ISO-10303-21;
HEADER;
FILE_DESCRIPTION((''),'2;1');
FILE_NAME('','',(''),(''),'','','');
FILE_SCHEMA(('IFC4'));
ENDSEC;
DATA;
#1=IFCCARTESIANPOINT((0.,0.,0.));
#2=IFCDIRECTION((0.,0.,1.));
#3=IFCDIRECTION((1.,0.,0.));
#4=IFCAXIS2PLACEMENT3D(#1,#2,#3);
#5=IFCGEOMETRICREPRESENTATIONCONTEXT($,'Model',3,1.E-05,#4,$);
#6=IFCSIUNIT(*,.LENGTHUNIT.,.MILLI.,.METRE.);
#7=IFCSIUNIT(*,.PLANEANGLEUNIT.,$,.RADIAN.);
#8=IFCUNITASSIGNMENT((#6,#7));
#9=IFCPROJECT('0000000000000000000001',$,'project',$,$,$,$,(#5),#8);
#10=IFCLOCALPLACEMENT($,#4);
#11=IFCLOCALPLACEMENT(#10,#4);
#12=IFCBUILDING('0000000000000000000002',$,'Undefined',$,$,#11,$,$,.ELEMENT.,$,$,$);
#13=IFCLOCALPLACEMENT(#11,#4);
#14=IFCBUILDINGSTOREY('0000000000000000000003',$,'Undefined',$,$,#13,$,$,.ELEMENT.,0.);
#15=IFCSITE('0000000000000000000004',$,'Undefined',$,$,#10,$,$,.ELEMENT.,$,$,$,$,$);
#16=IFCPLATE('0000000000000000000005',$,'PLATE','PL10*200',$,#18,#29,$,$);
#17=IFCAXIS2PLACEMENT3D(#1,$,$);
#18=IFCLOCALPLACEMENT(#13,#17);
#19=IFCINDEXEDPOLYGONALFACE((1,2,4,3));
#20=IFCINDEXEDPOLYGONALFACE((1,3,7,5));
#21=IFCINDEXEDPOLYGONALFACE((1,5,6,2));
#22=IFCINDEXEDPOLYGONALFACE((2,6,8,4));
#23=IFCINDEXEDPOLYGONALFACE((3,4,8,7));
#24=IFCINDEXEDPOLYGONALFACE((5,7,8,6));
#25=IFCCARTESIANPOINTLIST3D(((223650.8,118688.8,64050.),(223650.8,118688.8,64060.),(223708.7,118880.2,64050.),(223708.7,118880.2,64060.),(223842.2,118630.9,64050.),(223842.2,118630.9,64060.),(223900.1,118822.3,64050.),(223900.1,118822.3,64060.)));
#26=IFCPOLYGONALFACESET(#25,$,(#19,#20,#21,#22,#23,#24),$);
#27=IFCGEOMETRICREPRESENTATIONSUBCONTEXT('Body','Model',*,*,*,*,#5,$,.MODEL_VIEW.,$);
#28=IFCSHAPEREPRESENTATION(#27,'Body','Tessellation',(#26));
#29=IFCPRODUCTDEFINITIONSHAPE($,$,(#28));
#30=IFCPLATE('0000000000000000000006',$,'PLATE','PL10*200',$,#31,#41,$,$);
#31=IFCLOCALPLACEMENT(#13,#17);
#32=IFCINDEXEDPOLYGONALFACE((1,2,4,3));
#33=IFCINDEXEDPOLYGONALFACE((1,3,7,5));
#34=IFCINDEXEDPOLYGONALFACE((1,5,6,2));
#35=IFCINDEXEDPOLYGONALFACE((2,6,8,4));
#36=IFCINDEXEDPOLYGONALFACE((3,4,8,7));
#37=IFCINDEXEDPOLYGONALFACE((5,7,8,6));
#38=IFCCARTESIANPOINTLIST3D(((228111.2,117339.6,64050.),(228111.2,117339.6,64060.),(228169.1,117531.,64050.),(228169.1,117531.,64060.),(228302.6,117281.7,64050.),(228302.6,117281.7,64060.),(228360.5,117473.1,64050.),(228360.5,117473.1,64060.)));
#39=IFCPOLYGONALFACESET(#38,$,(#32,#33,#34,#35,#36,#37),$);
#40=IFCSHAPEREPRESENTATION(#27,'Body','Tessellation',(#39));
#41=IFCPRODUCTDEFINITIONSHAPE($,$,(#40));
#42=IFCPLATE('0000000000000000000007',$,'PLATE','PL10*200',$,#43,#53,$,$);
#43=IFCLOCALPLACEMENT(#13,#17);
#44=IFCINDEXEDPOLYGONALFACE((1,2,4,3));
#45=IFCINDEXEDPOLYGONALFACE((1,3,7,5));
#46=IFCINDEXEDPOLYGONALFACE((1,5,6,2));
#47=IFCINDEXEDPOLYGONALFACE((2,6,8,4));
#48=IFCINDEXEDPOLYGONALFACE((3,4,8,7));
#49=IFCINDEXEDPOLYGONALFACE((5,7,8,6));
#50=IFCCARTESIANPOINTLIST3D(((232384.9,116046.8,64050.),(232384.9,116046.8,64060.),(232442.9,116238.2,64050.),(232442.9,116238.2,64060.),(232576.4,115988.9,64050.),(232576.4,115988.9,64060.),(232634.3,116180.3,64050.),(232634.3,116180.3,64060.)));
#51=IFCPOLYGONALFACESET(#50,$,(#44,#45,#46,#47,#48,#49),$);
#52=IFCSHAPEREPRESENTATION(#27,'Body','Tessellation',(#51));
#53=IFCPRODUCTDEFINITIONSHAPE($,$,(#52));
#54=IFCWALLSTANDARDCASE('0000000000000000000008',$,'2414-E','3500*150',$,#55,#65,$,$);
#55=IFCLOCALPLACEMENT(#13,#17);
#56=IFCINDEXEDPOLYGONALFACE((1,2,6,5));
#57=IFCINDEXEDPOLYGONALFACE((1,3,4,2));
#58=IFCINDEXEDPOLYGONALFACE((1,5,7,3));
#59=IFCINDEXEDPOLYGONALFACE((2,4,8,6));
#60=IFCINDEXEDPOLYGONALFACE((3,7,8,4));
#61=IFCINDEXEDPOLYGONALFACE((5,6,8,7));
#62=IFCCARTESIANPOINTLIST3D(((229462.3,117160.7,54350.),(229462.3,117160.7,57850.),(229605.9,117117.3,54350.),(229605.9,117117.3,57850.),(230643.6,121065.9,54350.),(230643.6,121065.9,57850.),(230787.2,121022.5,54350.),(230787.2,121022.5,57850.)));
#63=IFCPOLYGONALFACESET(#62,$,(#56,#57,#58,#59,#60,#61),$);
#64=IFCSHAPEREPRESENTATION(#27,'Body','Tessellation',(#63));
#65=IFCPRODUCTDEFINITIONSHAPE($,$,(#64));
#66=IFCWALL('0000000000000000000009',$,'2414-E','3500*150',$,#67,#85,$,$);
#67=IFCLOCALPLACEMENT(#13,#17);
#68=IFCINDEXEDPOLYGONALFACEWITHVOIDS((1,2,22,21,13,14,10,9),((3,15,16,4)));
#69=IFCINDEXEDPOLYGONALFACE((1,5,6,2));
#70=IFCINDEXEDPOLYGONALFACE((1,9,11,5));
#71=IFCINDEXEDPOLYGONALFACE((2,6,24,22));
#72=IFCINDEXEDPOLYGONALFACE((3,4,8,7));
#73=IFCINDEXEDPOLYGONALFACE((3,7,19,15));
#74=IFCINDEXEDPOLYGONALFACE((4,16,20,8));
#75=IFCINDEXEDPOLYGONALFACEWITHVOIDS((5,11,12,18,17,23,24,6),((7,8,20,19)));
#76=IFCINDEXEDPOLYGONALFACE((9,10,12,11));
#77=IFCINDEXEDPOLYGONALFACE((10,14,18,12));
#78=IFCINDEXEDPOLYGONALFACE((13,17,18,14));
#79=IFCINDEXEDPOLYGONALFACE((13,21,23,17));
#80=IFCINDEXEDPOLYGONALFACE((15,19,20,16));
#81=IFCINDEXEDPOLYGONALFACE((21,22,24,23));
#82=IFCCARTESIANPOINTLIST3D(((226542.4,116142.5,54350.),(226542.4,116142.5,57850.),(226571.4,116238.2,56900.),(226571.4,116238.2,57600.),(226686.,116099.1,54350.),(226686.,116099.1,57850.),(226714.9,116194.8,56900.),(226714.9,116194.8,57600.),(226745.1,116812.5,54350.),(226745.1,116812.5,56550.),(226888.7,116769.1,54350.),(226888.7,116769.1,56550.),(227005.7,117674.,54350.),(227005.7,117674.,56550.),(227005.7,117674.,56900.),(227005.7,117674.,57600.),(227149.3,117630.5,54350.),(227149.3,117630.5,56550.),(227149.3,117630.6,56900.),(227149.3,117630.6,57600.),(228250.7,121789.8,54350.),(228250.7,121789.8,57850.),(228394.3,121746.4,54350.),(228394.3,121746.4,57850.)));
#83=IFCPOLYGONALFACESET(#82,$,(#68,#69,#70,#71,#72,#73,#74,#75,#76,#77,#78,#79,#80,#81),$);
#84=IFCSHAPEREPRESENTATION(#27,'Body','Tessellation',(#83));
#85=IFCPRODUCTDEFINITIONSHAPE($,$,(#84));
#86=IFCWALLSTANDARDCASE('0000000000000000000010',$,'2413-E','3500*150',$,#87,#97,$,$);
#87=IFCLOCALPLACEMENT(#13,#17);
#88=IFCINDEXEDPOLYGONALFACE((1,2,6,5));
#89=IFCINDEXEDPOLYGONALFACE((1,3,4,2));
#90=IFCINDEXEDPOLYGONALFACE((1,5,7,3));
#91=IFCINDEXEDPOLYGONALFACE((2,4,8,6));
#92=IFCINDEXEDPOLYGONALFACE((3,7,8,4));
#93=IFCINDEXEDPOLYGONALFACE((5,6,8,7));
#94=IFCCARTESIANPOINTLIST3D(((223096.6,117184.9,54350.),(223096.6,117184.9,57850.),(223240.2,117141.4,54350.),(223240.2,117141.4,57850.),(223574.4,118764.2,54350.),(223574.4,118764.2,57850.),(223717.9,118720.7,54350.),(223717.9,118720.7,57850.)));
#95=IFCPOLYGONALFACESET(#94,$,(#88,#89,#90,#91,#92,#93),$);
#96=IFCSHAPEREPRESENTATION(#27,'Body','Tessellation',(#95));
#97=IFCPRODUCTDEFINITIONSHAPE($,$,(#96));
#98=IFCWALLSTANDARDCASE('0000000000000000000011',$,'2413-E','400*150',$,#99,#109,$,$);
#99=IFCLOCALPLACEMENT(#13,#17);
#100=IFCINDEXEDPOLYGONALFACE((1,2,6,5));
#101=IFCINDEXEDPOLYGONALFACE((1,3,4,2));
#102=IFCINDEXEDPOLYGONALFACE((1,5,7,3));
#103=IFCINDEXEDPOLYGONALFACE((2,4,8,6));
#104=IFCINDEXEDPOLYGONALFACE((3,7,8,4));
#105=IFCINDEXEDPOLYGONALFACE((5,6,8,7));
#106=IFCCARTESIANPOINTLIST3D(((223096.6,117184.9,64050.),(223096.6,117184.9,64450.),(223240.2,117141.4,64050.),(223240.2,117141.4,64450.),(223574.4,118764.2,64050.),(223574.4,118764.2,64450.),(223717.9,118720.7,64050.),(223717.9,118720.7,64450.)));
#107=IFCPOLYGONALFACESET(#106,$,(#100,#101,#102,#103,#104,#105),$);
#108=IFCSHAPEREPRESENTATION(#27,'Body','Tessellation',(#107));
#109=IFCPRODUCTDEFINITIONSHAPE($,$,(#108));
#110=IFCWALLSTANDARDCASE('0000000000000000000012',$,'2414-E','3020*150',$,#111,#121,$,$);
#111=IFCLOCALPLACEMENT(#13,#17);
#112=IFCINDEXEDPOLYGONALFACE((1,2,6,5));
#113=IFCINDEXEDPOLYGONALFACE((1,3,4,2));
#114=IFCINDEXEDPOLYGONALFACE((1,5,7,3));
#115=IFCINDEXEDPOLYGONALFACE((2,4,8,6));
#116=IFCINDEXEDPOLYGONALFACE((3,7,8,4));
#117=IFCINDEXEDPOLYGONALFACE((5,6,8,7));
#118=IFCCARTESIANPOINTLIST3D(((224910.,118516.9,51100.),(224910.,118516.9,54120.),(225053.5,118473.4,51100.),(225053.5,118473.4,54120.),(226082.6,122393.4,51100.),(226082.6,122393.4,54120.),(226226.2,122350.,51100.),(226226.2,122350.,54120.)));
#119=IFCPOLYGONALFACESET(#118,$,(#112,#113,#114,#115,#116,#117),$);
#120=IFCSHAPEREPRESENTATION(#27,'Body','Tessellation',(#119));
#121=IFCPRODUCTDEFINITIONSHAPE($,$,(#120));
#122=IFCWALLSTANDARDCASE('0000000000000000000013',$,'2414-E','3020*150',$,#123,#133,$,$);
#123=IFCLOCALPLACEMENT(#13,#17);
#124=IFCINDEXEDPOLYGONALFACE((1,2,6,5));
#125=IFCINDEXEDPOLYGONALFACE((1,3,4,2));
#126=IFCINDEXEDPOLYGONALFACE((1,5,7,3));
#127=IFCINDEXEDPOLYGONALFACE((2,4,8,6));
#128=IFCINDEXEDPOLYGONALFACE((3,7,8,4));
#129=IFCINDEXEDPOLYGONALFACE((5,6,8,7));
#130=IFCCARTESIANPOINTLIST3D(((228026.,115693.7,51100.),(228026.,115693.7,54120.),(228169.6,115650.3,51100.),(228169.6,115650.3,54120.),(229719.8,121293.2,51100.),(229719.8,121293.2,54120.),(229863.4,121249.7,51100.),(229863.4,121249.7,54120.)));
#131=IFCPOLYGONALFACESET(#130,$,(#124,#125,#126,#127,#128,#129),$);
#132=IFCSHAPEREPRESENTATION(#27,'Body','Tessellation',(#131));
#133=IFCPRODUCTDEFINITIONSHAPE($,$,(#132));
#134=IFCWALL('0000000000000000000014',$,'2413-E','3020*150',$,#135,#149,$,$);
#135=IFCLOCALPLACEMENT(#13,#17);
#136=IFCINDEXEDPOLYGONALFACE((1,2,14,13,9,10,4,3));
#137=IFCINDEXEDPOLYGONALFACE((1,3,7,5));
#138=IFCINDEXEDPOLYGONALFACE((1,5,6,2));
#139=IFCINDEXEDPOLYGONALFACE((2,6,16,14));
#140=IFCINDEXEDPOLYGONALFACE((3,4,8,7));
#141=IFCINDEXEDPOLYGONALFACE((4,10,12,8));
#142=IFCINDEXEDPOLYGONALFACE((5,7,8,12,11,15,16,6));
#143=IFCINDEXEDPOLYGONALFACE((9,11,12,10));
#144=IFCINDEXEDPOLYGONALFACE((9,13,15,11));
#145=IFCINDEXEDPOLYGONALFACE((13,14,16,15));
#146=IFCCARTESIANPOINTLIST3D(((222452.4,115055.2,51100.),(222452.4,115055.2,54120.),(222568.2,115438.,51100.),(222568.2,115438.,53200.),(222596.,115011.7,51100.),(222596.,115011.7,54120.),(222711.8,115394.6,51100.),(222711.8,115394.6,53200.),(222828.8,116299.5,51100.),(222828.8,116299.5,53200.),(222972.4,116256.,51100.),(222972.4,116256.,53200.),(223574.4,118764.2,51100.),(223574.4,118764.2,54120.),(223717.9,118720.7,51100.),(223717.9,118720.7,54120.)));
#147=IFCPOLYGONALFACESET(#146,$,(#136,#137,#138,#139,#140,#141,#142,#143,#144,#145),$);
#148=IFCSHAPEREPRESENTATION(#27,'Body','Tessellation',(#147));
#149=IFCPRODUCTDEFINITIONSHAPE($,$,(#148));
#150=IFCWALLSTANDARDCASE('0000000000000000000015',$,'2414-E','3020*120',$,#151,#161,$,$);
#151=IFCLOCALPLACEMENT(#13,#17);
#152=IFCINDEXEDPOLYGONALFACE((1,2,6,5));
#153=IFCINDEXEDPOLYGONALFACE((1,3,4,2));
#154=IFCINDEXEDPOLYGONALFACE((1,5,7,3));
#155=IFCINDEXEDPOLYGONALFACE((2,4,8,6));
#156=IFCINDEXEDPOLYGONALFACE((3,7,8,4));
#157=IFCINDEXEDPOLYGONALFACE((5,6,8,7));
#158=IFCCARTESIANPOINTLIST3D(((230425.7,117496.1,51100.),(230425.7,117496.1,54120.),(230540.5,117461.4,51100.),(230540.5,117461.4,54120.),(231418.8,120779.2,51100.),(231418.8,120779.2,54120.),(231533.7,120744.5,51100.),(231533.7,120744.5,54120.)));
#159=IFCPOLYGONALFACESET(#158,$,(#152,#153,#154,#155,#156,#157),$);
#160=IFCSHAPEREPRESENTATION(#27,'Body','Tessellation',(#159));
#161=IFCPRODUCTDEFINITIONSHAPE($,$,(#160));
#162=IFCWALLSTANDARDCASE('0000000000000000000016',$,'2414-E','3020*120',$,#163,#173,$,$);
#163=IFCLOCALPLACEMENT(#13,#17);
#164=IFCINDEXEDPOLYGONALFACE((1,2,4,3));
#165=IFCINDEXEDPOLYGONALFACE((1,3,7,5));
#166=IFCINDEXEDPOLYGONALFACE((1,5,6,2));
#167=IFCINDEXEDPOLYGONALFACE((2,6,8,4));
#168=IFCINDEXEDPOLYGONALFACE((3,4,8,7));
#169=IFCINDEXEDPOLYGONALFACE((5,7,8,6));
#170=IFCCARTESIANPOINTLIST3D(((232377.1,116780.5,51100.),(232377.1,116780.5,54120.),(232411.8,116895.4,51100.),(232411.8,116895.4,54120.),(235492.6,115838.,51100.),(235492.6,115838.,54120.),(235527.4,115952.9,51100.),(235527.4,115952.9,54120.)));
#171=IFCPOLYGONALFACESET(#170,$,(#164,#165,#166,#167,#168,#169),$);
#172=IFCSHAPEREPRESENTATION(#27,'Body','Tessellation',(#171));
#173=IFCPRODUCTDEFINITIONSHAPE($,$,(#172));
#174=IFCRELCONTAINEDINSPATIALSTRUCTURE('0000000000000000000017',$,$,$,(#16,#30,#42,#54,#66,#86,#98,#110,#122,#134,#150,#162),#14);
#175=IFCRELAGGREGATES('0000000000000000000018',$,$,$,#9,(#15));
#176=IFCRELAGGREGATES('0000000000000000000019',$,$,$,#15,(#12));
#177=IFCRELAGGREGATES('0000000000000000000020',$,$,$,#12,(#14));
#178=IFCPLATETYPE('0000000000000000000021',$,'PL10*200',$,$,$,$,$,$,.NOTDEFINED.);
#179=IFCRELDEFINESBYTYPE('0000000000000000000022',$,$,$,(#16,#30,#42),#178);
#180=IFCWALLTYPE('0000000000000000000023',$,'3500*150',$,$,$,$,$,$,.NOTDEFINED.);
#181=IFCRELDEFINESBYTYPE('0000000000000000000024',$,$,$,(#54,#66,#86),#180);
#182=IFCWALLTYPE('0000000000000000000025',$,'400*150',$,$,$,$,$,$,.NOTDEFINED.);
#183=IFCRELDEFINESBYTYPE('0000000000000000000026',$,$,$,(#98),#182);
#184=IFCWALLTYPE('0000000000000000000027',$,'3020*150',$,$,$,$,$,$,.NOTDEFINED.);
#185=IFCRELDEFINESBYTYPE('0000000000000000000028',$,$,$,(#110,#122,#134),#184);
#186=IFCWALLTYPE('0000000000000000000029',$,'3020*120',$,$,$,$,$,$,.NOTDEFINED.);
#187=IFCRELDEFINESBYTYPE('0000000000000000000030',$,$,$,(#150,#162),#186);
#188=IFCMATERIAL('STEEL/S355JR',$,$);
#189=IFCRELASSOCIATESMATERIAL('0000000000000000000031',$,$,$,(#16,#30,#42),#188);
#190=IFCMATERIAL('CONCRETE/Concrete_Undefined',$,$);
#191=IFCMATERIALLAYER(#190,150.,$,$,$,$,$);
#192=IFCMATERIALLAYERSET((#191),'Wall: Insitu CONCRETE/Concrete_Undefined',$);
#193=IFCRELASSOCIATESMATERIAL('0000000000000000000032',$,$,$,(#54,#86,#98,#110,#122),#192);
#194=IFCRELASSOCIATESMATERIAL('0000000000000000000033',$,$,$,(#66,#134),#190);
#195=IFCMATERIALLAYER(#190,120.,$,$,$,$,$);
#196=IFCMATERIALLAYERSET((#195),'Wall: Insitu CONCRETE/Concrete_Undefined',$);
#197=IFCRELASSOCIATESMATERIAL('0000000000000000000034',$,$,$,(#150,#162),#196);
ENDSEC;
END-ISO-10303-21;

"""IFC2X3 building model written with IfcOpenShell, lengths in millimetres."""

from ifc_helpers import new_model, si_unit, frame, frame_2d, origin_with_axes, place, context, subcontext, project, spatial, polyline, rectangle, outline, extrude, boolean, material, layer, layer_set, layer_usage, type_object, element, save


model = new_model("IFC2X3")

# Units and contexts
model_context = context("Model", 3, precision=1e-05, world=origin_with_axes())
body_context = subcontext(model_context, "Body", "Model", "MODEL_VIEW")
ifc_project = project(units=[si_unit("LENGTHUNIT", "METRE", prefix="MILLI"), si_unit("PLANEANGLEUNIT", "RADIAN")], contexts=[model_context])

# Site, building, storey
site_placement = place(None, origin_with_axes())
site = spatial("IfcSite", under=ifc_project, at=site_placement, Name="Undefined", CompositionType="ELEMENT")
building_placement = place(site_placement, origin_with_axes())
building = spatial("IfcBuilding", under=site, at=building_placement, Name="Undefined", CompositionType="ELEMENT")
storey_placement = place(building_placement, origin_with_axes())
storey = spatial("IfcBuildingStorey", under=building, at=storey_placement, Name="Undefined", CompositionType="ELEMENT", Elevation=0.0)

# Plates
ifc_material_1 = material(Name="STEEL/S355JR")
plate_type = type_object("IfcPlateType", Name="PL10*200", PredefinedType="NOTDEFINED")
for number, where, z_axis, x_axis, name in (
    (1, (223871.2, 118726.6, 64055.0), (0.0, 0.0, 1.0), (-0.957167, 0.289538, 0.0), "PLATE"),
    (2, (228331.6, 117377.4, 64055.0), (0.0, 0.0, 1.0), (-0.957167, 0.289538, 0.0), "PLATE"),
    (3, (232605.3, 116084.6, 64055.0), (0.0, 0.0, 1.0), (-0.957167, 0.289538, 0.0), "PLATE"),
):
    element("IfcPlate", number, at=place(storey_placement, frame(where, z_axis=z_axis, x_axis=x_axis)), inside=storey, type_object=plate_type, material=ifc_material_1, Name=name, Description="PL10*200", context=body_context, shape_type="SweptSolid", body=[
        extrude(outline(polyline([(200.0, 100.0), (200.0, -100.0), (0.0, -100.0), (0.0, 100.0), (200.0, 100.0)])), frame((0.0, 0.0, -5.0), z_axis=(0.0, 0.0, 1.0), x_axis=(1.0, 0.0, 0.0)), (0.0, 0.0, 1.0), 10.0),
    ])

# Walls
ifc_material_2 = material(Name="CONCRETE/Concrete_Undefined")
ifc_layer_1 = layer(ifc_material_2, 150.0)
ifc_layer_set_1 = layer_set([ifc_layer_1], Name="Wall: Insitu CONCRETE/Concrete_Undefined")
ifc_layer_usage_1 = layer_usage(ifc_layer_set_1, "AXIS2", "POSITIVE", -75.0)
wall_type_1 = type_object("IfcWallType", Name="3500*150", PredefinedType="NOTDEFINED")
wall_1_placement = place(storey_placement, frame((229534.1, 117139.0, 54350.0), z_axis=(0.0, 0.0, 1.0), x_axis=(0.289539, 0.957166, 0.0)))
element("IfcWallStandardCase", 4, at=wall_1_placement, inside=storey, type_object=wall_type_1, material=ifc_layer_usage_1, Name="2414-E", Description="3500*150", context=body_context, shape_type="SweptSolid", body=[
    extrude(rectangle(XDim=4080.0, YDim=150.0, at=frame_2d((0.0, 2040.0), x_axis=(0.0, -1.0))), frame((0.0, 0.0, 0.0), z_axis=(0.0, 0.0, 1.0), x_axis=(0.0, -1.0, 0.0)), (0.0, 0.0, 1.0), 3500.0),
])
wall_2_placement = place(storey_placement, frame((226614.2, 116120.8, 54350.0), z_axis=(0.0, 0.0, 1.0), x_axis=(0.289538, 0.957166, 0.0)))
element("IfcWall", 5, at=wall_2_placement, inside=storey, type_object=wall_type_1, material=ifc_material_2, Name="2414-E", Description="3500*150", context=body_context, shape_type="CSG", body=[
    boolean("DIFFERENCE", boolean("DIFFERENCE", extrude(rectangle(XDim=5900.0, YDim=150.0, at=frame_2d((0.0, 2950.0), x_axis=(0.0, -1.0))), frame((0.0, 0.0, 0.0), z_axis=(0.0, 0.0, 1.0), x_axis=(0.0, -1.0, 0.0)), (0.0, 0.0, 1.0), 3500.0), extrude(rectangle(XDim=1500.0, YDim=200.0, at=frame_2d((0.0, 750.0), x_axis=(0.0, -1.0))), frame((1600.0, -25.0, 2550.0), z_axis=(0.0, 0.0, 1.0), x_axis=(0.0, 1.0, 0.0)), (0.0, 0.0, 1.0), 700.0)), extrude(rectangle(XDim=900.0, YDim=150.0, at=frame_2d((0.0, 450.0), x_axis=(0.0, -1.0))), frame((700.0, 0.0, 0.0), z_axis=(0.0, 0.0, 1.0), x_axis=(-0.000003, -1.0, 0.0)), (0.0, 0.0, 1.0), 2200.0)),
])
ifc_layer_usage_2 = layer_usage(ifc_layer_set_1, "AXIS2", "POSITIVE", -75.0)
wall_3_placement = place(storey_placement, frame((223646.1, 118742.5, 54350.0), z_axis=(0.0, 0.0, 1.0), x_axis=(-0.289535, -0.957167, 0.0)))
element("IfcWallStandardCase", 6, at=wall_3_placement, inside=storey, type_object=wall_type_1, material=ifc_layer_usage_2, Name="2413-E", Description="3500*150", context=body_context, shape_type="SweptSolid", body=[
    extrude(rectangle(XDim=1650.0, YDim=150.0, at=frame_2d((0.0, 825.0), x_axis=(0.0, -1.0))), frame((0.0, 0.0, 0.0), z_axis=(0.0, 0.0, 1.0), x_axis=(0.0, -1.0, 0.0)), (0.0, 0.0, 1.0), 3500.0),
])
ifc_layer_usage_3 = layer_usage(ifc_layer_set_1, "AXIS2", "POSITIVE", -75.0)
wall_type_2 = type_object("IfcWallType", Name="400*150", PredefinedType="NOTDEFINED")
wall_4_placement = place(storey_placement, frame((223646.1, 118742.5, 64050.0), z_axis=(0.0, 0.0, 1.0), x_axis=(-0.289535, -0.957167, 0.0)))
element("IfcWallStandardCase", 7, at=wall_4_placement, inside=storey, type_object=wall_type_2, material=ifc_layer_usage_3, Name="2413-E", Description="400*150", context=body_context, shape_type="SweptSolid", body=[
    extrude(rectangle(XDim=1650.0, YDim=150.0, at=frame_2d((0.0, 825.0), x_axis=(0.0, -1.0))), frame((0.0, 0.0, 0.0), z_axis=(0.0, 0.0, 1.0), x_axis=(0.0, -1.0, 0.0)), (0.0, 0.0, 1.0), 400.0),
])
ifc_layer_usage_4 = layer_usage(ifc_layer_set_1, "AXIS2", "POSITIVE", -75.0)
wall_type_3 = type_object("IfcWallType", Name="3020*150", PredefinedType="NOTDEFINED")
wall_5_placement = place(storey_placement, frame((224981.7, 118495.2, 51100.0), z_axis=(0.0, 0.0, 1.0), x_axis=(0.289539, 0.957166, 0.0)))
element("IfcWallStandardCase", 8, at=wall_5_placement, inside=storey, type_object=wall_type_3, material=ifc_layer_usage_4, Name="2414-E", Description="3020*150", context=body_context, shape_type="SweptSolid", body=[
    extrude(rectangle(XDim=4050.0, YDim=150.0, at=frame_2d((0.0, 2025.0), x_axis=(0.0, -1.0))), frame((0.0, 0.0, 0.0), z_axis=(0.0, 0.0, 1.0), x_axis=(0.0, -1.0, 0.0)), (0.0, 0.0, 1.0), 3020.0),
])
ifc_layer_usage_5 = layer_usage(ifc_layer_set_1, "AXIS2", "POSITIVE", -75.0)
wall_6_placement = place(storey_placement, frame((228097.8, 115672.0, 51100.0), z_axis=(0.0, 0.0, 1.0), x_axis=(0.289538, 0.957166, 0.0)))
element("IfcWallStandardCase", 9, at=wall_6_placement, inside=storey, type_object=wall_type_3, material=ifc_layer_usage_5, Name="2414-E", Description="3020*150", context=body_context, shape_type="SweptSolid", body=[
    extrude(rectangle(XDim=5850.0, YDim=150.0, at=frame_2d((0.0, 2925.0), x_axis=(0.0, -1.0))), frame((0.0, 0.0, 0.0), z_axis=(0.0, 0.0, 1.0), x_axis=(0.0, -1.0, 0.0)), (0.0, 0.0, 1.0), 3020.0),
])
wall_7_placement = place(storey_placement, frame((223646.1, 118742.5, 51100.0), z_axis=(0.0, 0.0, 1.0), x_axis=(-0.289536, -0.957167, 0.0)))
element("IfcWall", 10, at=wall_7_placement, inside=storey, type_object=wall_type_3, material=ifc_material_2, Name="2413-E", Description="3020*150", context=body_context, shape_type="CSG", body=[
    boolean("DIFFERENCE", extrude(rectangle(XDim=3875.0, YDim=150.0, at=frame_2d((0.0, 1937.5), x_axis=(0.0, -1.0))), frame((0.0, 0.0, 0.0), z_axis=(0.0, 0.0, 1.0), x_axis=(0.0, -1.0, 0.0)), (0.0, 0.0, 1.0), 3020.0), extrude(rectangle(XDim=900.0, YDim=200.0, at=frame_2d((0.0, 450.0), x_axis=(0.0, -1.0))), frame((2575.0, 25.0, 0.0), z_axis=(0.0, 0.0, 1.0), x_axis=(-0.000006, -1.0, 0.0)), (0.0, 0.0, 1.0), 2100.0)),
])
ifc_layer_2 = layer(ifc_material_2, 120.0)
ifc_layer_set_2 = layer_set([ifc_layer_2], Name="Wall: Insitu CONCRETE/Concrete_Undefined")
ifc_layer_usage_6 = layer_usage(ifc_layer_set_2, "AXIS2", "POSITIVE", -60.0)
wall_type_4 = type_object("IfcWallType", Name="3020*120", PredefinedType="NOTDEFINED")
wall_8_placement = place(storey_placement, frame((230483.1, 117478.8, 51100.0), z_axis=(0.0, 0.0, 1.0), x_axis=(0.289539, 0.957166, 0.0)))
element("IfcWallStandardCase", 11, at=wall_8_placement, inside=storey, type_object=wall_type_4, material=ifc_layer_usage_6, Name="2414-E", Description="3020*120", context=body_context, shape_type="SweptSolid", body=[
    extrude(rectangle(XDim=3430.0, YDim=120.0, at=frame_2d((0.0, 1715.0), x_axis=(0.0, -1.0))), frame((0.0, 0.0, 0.0), z_axis=(0.0, 0.0, 1.0), x_axis=(0.0, -1.0, 0.0)), (0.0, 0.0, 1.0), 3020.0),
])
ifc_layer_usage_7 = layer_usage(ifc_layer_set_2, "AXIS2", "POSITIVE", -60.0)
wall_9_placement = place(storey_placement, frame((235510.0, 115895.5, 51100.0), z_axis=(0.0, 0.0, 1.0), x_axis=(-0.957165, 0.289542, 0.0)))
element("IfcWallStandardCase", 12, at=wall_9_placement, inside=storey, type_object=wall_type_4, material=ifc_layer_usage_7, Name="2414-E", Description="3020*120", context=body_context, shape_type="SweptSolid", body=[
    extrude(rectangle(XDim=3255.0, YDim=120.0, at=frame_2d((0.0, 1627.5), x_axis=(0.0, -1.0))), frame((0.0, 0.0, 0.0), z_axis=(0.0, 0.0, 1.0), x_axis=(0.0, -1.0, 0.0)), (0.0, 0.0, 1.0), 3020.0),
])

save(model, "model.ifc")
